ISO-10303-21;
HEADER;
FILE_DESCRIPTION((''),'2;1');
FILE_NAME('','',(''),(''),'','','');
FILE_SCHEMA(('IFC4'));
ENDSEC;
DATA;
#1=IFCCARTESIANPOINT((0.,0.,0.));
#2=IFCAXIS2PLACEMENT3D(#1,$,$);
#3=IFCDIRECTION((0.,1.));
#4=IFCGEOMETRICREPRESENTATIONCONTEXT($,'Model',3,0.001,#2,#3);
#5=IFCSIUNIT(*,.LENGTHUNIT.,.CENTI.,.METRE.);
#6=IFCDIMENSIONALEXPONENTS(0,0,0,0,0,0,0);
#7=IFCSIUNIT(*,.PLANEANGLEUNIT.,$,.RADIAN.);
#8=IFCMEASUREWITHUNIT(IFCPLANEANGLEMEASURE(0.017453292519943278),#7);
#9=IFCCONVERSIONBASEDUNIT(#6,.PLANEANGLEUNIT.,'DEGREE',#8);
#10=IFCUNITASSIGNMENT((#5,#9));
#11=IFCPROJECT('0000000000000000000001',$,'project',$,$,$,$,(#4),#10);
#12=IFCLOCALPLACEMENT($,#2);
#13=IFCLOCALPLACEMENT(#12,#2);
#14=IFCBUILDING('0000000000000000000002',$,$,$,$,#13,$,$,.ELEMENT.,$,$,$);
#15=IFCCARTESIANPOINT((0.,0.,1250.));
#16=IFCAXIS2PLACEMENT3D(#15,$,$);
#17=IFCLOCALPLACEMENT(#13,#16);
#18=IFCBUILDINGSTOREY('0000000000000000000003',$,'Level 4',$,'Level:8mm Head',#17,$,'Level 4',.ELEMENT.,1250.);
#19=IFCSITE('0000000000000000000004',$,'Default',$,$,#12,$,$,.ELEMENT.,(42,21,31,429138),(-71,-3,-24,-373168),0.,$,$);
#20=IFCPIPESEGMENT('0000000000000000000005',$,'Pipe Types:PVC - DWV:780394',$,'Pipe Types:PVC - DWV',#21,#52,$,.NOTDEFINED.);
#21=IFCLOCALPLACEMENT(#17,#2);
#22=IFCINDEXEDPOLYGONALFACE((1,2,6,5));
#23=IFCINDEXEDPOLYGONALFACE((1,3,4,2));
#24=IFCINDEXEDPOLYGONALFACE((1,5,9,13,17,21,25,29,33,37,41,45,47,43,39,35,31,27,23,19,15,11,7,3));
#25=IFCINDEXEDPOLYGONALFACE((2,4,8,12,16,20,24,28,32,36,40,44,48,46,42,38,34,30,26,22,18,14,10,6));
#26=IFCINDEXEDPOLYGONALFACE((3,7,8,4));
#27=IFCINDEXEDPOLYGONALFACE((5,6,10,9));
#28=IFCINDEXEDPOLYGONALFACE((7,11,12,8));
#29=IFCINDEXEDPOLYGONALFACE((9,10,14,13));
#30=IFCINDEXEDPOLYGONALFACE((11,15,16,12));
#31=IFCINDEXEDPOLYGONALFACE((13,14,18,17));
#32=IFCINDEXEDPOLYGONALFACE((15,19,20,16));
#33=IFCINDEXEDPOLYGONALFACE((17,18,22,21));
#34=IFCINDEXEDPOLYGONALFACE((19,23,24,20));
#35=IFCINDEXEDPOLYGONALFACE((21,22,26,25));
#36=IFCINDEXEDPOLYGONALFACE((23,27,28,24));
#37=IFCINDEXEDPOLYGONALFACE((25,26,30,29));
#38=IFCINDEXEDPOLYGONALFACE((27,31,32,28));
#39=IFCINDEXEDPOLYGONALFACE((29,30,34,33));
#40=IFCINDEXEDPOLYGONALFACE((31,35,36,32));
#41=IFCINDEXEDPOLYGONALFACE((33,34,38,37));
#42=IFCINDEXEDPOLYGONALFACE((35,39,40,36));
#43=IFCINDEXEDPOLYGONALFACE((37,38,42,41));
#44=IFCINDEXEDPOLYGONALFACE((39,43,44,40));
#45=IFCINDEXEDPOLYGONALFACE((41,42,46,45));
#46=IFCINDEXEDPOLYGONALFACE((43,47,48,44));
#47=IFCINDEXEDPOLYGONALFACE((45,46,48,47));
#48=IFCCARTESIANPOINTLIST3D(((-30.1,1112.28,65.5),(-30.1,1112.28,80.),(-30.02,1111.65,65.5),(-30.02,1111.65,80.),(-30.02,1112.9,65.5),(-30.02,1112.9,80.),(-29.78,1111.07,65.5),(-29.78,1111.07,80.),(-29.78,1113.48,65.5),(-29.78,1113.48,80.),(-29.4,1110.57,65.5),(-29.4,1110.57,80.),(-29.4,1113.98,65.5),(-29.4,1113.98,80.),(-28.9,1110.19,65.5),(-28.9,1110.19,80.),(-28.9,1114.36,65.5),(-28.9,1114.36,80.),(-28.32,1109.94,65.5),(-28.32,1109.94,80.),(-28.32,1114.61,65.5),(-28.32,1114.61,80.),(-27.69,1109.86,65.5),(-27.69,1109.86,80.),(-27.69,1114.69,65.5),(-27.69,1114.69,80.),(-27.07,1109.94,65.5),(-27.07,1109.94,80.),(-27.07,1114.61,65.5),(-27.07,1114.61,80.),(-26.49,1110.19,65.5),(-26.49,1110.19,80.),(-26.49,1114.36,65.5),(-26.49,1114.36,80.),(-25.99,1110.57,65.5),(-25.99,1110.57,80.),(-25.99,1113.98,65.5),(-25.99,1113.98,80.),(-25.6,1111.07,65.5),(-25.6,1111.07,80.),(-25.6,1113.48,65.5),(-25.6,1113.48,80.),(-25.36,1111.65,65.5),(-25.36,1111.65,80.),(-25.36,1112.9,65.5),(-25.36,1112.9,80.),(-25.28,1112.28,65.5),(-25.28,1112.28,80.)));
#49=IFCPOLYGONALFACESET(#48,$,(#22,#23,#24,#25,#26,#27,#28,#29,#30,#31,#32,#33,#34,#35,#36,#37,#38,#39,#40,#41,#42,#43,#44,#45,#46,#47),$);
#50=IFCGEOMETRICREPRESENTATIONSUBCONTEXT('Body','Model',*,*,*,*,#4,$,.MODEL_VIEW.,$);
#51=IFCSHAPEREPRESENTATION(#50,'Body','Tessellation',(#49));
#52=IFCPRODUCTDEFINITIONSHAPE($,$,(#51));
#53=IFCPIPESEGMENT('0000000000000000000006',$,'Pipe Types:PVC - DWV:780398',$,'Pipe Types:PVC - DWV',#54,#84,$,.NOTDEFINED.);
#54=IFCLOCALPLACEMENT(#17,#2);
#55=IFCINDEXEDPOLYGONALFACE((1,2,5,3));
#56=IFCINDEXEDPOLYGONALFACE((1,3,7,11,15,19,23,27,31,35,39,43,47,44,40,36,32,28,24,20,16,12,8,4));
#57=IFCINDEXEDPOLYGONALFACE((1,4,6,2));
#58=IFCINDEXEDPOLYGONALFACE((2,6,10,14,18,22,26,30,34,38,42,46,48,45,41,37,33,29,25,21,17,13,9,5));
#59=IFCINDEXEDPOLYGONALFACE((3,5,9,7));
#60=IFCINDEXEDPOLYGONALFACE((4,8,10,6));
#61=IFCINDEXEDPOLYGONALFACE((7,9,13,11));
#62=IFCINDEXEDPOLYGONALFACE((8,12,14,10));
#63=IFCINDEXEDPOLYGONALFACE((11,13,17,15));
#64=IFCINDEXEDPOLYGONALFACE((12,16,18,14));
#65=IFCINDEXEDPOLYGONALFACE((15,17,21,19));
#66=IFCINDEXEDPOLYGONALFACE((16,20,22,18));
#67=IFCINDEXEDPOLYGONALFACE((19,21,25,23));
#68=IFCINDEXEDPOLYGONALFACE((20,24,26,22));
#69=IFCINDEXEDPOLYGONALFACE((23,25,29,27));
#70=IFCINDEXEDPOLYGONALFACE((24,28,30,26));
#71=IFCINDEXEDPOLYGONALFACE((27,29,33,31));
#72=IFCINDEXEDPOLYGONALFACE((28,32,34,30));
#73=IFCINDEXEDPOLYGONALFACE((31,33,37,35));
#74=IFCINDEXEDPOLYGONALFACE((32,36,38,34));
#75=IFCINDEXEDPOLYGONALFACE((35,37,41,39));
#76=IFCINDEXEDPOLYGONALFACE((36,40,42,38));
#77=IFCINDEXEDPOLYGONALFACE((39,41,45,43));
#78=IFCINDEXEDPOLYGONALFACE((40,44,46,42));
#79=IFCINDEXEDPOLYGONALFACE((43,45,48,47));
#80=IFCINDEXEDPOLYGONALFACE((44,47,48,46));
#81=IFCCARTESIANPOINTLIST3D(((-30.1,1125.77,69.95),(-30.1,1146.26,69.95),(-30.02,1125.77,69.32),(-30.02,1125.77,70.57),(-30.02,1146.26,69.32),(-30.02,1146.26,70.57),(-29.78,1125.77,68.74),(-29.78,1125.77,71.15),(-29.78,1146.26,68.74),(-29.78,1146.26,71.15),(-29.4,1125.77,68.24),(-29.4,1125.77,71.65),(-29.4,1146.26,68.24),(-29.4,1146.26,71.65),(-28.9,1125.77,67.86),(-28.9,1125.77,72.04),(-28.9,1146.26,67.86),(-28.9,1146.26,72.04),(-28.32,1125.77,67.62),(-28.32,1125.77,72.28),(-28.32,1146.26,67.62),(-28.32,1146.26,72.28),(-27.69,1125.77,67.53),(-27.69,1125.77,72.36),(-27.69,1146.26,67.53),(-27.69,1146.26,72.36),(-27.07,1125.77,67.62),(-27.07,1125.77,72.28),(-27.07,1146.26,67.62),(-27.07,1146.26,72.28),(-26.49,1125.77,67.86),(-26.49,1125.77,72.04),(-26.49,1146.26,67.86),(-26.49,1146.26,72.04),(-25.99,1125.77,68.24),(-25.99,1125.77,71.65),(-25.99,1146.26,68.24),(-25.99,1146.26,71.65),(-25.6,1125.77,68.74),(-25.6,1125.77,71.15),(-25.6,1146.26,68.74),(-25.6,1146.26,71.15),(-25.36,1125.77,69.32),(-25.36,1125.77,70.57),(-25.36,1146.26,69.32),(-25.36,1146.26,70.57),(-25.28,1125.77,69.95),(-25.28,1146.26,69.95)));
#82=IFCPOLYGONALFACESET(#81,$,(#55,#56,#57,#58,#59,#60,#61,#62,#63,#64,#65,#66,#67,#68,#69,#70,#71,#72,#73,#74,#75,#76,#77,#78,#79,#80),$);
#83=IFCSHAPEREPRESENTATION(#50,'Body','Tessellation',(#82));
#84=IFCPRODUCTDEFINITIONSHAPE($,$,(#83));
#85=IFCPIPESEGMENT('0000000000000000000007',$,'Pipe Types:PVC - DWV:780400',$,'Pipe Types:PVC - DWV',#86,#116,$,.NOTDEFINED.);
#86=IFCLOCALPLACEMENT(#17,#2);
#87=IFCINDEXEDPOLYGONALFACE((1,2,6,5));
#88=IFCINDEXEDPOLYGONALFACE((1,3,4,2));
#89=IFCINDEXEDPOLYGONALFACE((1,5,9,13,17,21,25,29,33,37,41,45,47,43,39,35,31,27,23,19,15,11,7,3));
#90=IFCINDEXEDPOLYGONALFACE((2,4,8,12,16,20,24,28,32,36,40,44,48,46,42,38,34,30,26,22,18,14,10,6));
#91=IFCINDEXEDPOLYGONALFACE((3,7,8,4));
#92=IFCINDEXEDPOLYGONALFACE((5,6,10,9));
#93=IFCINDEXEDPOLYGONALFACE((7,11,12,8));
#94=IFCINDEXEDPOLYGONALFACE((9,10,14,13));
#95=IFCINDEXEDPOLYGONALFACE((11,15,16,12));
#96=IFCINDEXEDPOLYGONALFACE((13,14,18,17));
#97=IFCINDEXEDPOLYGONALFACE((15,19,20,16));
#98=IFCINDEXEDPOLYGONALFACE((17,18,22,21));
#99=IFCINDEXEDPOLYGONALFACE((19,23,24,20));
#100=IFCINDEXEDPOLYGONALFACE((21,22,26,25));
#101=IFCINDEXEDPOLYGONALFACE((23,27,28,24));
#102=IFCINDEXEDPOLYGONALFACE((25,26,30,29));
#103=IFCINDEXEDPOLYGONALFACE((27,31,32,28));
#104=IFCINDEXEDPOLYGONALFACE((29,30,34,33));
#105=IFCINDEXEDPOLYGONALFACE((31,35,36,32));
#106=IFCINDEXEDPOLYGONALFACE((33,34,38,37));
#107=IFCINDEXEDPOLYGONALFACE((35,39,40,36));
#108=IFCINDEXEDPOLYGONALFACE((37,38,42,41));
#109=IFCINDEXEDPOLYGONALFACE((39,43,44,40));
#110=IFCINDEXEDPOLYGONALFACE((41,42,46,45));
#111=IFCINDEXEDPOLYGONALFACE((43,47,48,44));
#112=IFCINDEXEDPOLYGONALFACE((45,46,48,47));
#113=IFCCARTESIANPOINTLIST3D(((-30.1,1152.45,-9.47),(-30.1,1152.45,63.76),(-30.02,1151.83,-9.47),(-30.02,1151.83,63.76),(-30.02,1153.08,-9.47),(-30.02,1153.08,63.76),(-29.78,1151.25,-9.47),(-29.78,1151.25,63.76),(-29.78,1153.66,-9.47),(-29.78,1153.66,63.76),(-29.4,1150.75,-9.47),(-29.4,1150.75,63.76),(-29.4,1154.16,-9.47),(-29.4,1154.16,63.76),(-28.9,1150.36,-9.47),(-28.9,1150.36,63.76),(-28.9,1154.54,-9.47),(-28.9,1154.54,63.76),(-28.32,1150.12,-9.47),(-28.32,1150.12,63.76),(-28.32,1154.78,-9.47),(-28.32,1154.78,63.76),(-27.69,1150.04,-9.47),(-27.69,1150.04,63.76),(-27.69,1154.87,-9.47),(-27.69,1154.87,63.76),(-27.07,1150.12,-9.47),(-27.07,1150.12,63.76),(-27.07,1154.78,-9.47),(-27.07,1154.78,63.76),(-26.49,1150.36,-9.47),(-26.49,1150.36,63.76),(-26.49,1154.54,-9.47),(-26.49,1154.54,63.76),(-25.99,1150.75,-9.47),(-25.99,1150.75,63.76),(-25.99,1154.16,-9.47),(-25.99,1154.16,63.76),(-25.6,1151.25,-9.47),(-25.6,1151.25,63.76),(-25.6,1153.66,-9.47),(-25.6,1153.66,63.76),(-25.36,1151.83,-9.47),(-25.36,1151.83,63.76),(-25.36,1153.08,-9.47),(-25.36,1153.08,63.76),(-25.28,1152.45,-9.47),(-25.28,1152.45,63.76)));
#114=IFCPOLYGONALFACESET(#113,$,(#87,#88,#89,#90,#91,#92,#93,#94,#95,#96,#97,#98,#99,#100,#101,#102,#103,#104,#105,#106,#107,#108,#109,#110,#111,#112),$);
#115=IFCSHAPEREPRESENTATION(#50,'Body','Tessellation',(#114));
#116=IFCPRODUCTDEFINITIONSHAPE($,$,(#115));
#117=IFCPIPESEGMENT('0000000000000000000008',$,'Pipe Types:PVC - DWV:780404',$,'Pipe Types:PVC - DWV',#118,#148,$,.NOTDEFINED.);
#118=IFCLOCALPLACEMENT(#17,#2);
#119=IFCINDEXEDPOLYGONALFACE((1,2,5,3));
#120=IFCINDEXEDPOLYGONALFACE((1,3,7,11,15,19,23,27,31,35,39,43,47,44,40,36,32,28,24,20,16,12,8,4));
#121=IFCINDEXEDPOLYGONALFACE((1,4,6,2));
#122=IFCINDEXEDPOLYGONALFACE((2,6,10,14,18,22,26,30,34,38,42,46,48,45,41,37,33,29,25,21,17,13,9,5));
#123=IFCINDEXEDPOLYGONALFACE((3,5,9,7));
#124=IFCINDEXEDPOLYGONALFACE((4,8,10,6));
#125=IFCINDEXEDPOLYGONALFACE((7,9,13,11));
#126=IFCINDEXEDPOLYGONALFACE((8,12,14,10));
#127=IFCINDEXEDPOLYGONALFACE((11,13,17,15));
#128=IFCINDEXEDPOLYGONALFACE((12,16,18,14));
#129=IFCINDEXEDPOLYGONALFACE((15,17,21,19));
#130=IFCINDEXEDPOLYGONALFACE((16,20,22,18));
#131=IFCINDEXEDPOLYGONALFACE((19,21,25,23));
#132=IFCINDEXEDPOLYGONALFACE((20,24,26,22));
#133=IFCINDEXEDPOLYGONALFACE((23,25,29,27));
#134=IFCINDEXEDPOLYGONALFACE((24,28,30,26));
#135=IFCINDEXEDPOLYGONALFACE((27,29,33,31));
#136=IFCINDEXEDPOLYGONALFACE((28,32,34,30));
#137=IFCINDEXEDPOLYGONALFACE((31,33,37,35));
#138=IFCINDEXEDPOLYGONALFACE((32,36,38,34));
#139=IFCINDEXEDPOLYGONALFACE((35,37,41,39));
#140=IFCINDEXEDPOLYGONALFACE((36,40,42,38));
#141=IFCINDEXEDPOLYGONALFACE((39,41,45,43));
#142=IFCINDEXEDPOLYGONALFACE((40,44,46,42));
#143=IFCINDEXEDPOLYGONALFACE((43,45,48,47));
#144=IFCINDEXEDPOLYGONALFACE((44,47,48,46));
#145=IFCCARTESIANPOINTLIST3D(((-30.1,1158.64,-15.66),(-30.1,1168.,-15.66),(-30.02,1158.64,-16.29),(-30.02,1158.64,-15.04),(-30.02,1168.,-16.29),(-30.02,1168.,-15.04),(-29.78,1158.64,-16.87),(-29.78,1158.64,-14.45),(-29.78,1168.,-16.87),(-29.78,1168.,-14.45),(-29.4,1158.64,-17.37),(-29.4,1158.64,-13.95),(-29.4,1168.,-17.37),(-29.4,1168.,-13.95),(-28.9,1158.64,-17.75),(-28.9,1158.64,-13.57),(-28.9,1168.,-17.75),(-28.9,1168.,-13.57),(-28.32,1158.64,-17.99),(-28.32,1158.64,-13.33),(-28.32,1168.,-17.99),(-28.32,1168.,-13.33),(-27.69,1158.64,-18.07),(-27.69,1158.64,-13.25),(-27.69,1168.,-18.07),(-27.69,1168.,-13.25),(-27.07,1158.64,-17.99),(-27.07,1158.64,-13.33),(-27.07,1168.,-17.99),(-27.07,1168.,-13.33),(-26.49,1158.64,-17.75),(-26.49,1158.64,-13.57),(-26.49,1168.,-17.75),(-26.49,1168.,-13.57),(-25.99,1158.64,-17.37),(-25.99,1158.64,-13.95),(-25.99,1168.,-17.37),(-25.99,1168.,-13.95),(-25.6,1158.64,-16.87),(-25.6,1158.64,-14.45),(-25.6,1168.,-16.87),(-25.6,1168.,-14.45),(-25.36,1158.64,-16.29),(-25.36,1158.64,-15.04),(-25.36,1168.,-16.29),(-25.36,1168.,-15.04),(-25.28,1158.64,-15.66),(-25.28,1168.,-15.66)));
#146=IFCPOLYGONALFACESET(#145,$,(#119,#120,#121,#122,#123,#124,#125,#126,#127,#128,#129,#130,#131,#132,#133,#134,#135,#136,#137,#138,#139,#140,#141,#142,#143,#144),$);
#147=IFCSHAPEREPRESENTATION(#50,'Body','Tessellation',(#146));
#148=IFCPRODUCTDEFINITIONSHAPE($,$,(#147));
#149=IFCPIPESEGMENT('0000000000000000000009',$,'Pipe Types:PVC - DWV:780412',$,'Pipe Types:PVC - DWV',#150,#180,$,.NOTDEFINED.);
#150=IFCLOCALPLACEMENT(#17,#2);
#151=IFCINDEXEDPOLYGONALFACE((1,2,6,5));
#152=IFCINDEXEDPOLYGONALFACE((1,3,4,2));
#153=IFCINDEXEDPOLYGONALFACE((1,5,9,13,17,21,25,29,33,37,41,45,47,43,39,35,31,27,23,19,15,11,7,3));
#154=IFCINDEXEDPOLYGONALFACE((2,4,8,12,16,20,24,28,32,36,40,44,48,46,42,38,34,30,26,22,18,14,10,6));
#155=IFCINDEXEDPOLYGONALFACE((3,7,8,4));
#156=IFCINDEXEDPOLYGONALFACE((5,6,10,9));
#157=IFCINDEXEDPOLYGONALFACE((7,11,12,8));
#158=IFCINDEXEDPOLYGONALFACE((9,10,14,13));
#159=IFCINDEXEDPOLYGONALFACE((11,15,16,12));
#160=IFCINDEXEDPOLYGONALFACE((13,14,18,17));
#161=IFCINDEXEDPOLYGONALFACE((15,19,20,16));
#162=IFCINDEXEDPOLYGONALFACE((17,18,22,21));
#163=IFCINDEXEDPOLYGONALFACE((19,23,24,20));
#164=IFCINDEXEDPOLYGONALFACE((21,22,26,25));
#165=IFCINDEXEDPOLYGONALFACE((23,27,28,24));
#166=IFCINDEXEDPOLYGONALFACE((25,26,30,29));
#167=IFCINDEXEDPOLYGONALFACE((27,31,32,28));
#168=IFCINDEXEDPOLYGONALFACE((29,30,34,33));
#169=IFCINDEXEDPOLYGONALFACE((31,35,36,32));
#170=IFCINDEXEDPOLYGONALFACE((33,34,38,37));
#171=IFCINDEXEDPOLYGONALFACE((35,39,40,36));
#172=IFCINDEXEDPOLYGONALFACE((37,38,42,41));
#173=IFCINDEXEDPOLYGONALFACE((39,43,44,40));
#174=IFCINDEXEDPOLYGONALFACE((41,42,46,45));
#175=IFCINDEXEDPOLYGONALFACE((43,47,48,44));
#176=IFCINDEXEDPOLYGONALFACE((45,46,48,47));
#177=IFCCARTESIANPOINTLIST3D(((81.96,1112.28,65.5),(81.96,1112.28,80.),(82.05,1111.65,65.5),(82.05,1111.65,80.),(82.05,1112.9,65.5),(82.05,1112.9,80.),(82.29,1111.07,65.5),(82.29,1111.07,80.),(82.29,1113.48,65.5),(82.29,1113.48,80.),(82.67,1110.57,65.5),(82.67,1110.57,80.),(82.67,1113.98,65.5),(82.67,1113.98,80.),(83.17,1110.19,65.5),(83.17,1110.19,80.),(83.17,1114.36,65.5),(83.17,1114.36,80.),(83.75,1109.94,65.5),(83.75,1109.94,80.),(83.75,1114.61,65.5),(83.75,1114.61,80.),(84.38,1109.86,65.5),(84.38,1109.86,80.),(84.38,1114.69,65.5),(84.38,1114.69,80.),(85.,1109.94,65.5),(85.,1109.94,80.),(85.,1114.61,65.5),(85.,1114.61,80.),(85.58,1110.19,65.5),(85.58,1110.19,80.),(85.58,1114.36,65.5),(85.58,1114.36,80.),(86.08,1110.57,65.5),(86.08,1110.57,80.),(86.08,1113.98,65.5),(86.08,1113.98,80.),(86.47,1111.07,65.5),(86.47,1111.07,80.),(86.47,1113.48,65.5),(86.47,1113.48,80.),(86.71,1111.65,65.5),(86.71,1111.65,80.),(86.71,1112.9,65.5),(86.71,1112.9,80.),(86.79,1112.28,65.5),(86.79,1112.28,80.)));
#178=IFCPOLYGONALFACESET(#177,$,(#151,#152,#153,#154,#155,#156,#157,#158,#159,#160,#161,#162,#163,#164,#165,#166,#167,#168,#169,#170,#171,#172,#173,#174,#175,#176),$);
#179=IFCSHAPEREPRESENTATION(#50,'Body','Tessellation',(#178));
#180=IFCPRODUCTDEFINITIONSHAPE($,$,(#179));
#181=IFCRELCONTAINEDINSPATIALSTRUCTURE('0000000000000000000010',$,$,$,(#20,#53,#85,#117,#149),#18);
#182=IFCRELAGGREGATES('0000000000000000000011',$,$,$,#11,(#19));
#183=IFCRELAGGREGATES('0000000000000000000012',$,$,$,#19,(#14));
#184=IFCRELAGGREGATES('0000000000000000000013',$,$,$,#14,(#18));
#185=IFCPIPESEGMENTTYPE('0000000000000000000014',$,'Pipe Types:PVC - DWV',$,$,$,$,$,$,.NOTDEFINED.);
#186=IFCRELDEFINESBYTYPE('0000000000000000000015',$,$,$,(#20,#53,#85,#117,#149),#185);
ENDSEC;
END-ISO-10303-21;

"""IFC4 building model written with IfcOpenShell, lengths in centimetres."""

from ifc_helpers import new_model, entity, si_unit, converted_unit, direction, frame, origin, place, context, subcontext, project, spatial, arc, indexed_curve, outline, extrude, type_object, element, save


model = new_model("IFC4")

# Units and contexts
model_context = context("Model", 3, precision=0.001, world=origin(), true_north=direction((0.0, 1.0)))
body_context = subcontext(model_context, "Body", "Model", "MODEL_VIEW")
ifc_project = project(units=[si_unit("LENGTHUNIT", "METRE", prefix="CENTI"), converted_unit("PLANEANGLEUNIT", "DEGREE", entity("IfcPlaneAngleMeasure", 0.017453292519943278), si_unit("PLANEANGLEUNIT", "RADIAN"), dimensions=[0, 0, 0, 0, 0, 0, 0])], contexts=[model_context])

# Site, building, storey
site_placement = place(None, origin())
site = spatial("IfcSite", under=ifc_project, at=site_placement, Name="Default", CompositionType="ELEMENT", RefLatitude=(42, 21, 31, 429138), RefLongitude=(-71, -3, -24, -373168), RefElevation=0.0)
building_placement = place(site_placement, origin())
building = spatial("IfcBuilding", under=site, at=building_placement, CompositionType="ELEMENT")
storey_placement = place(building_placement, frame((0.0, 0.0, 1250.0)))
storey = spatial("IfcBuildingStorey", under=building, at=storey_placement, Name="Level 4", ObjectType="Level:8mm Head", LongName="Level 4", CompositionType="ELEMENT", Elevation=1250.0)

# Pipe segments
pipe_segment_type = type_object("IfcPipeSegmentType", Name="Pipe Types:PVC - DWV", PredefinedType="NOTDEFINED")
pipe_segment_1_placement = place(storey_placement, origin())
element("IfcPipeSegment", 1, at=pipe_segment_1_placement, inside=storey, type_object=pipe_segment_type, Name="Pipe Types:PVC - DWV:780394", ObjectType="Pipe Types:PVC - DWV", PredefinedType="NOTDEFINED", context=body_context, shape_type="SweptSolid", body=[
    extrude(outline(indexed_curve([(2.41, 0.0), (1.71, 1.71), (0.0, 2.41), (-1.71, 1.71), (-2.41, 0.0), (-1.71, -1.71), (0.0, -2.41), (1.71, -1.71)], segments=[arc(1, 2, 3), arc(3, 4, 5), arc(5, 6, 7), arc(7, 8, 1)], self_intersect=False)), frame((-27.69, 1112.28, 65.5)), (0.0, 0.0, 1.0), 14.5),
])
pipe_segment_2_placement = place(storey_placement, origin())
element("IfcPipeSegment", 2, at=pipe_segment_2_placement, inside=storey, type_object=pipe_segment_type, Name="Pipe Types:PVC - DWV:780398", ObjectType="Pipe Types:PVC - DWV", PredefinedType="NOTDEFINED", context=body_context, shape_type="SweptSolid", body=[
    extrude(outline(indexed_curve([(2.41, 0.0), (1.71, 1.71), (0.0, 2.41), (-1.71, 1.71), (-2.41, 0.0), (-1.71, -1.71), (0.0, -2.41), (1.71, -1.71)], segments=[arc(1, 2, 3), arc(3, 4, 5), arc(5, 6, 7), arc(7, 8, 1)], self_intersect=False)), frame((-27.69, 1125.77, 69.95), z_axis=(0.0, 1.0, 0.0), x_axis=(1.0, 0.0, 0.0)), (0.0, 0.0, 1.0), 20.5),
])
pipe_segment_3_placement = place(storey_placement, origin())
element("IfcPipeSegment", 3, at=pipe_segment_3_placement, inside=storey, type_object=pipe_segment_type, Name="Pipe Types:PVC - DWV:780400", ObjectType="Pipe Types:PVC - DWV", PredefinedType="NOTDEFINED", context=body_context, shape_type="SweptSolid", body=[
    extrude(outline(indexed_curve([(2.41, 0.0), (1.71, 1.71), (0.0, 2.41), (-1.71, 1.71), (-2.41, 0.0), (-1.71, -1.71), (0.0, -2.41), (1.71, -1.71)], segments=[arc(1, 2, 3), arc(3, 4, 5), arc(5, 6, 7), arc(7, 8, 1)], self_intersect=False)), frame((-27.69, 1152.45, -9.47)), (0.0, 0.0, 1.0), 73.23),
])
pipe_segment_4_placement = place(storey_placement, origin())
element("IfcPipeSegment", 4, at=pipe_segment_4_placement, inside=storey, type_object=pipe_segment_type, Name="Pipe Types:PVC - DWV:780404", ObjectType="Pipe Types:PVC - DWV", PredefinedType="NOTDEFINED", context=body_context, shape_type="SweptSolid", body=[
    extrude(outline(indexed_curve([(2.41, 0.0), (1.71, 1.71), (0.0, 2.41), (-1.71, 1.71), (-2.41, 0.0), (-1.71, -1.71), (0.0, -2.41), (1.71, -1.71)], segments=[arc(1, 2, 3), arc(3, 4, 5), arc(5, 6, 7), arc(7, 8, 1)], self_intersect=False)), frame((-27.69, 1158.64, -15.66), z_axis=(0.0, 1.0, 0.0), x_axis=(1.0, 0.0, 0.0)), (0.0, 0.0, 1.0), 9.36),
])
pipe_segment_5_placement = place(storey_placement, origin())
element("IfcPipeSegment", 5, at=pipe_segment_5_placement, inside=storey, type_object=pipe_segment_type, Name="Pipe Types:PVC - DWV:780412", ObjectType="Pipe Types:PVC - DWV", PredefinedType="NOTDEFINED", context=body_context, shape_type="SweptSolid", body=[
    extrude(outline(indexed_curve([(2.41, 0.0), (1.71, 1.71), (0.0, 2.41), (-1.71, 1.71), (-2.41, 0.0), (-1.71, -1.71), (0.0, -2.41), (1.71, -1.71)], segments=[arc(1, 2, 3), arc(3, 4, 5), arc(5, 6, 7), arc(7, 8, 1)], self_intersect=False)), frame((84.38, 1112.28, 65.5)), (0.0, 0.0, 1.0), 14.5),
])

save(model, "model.ifc")
